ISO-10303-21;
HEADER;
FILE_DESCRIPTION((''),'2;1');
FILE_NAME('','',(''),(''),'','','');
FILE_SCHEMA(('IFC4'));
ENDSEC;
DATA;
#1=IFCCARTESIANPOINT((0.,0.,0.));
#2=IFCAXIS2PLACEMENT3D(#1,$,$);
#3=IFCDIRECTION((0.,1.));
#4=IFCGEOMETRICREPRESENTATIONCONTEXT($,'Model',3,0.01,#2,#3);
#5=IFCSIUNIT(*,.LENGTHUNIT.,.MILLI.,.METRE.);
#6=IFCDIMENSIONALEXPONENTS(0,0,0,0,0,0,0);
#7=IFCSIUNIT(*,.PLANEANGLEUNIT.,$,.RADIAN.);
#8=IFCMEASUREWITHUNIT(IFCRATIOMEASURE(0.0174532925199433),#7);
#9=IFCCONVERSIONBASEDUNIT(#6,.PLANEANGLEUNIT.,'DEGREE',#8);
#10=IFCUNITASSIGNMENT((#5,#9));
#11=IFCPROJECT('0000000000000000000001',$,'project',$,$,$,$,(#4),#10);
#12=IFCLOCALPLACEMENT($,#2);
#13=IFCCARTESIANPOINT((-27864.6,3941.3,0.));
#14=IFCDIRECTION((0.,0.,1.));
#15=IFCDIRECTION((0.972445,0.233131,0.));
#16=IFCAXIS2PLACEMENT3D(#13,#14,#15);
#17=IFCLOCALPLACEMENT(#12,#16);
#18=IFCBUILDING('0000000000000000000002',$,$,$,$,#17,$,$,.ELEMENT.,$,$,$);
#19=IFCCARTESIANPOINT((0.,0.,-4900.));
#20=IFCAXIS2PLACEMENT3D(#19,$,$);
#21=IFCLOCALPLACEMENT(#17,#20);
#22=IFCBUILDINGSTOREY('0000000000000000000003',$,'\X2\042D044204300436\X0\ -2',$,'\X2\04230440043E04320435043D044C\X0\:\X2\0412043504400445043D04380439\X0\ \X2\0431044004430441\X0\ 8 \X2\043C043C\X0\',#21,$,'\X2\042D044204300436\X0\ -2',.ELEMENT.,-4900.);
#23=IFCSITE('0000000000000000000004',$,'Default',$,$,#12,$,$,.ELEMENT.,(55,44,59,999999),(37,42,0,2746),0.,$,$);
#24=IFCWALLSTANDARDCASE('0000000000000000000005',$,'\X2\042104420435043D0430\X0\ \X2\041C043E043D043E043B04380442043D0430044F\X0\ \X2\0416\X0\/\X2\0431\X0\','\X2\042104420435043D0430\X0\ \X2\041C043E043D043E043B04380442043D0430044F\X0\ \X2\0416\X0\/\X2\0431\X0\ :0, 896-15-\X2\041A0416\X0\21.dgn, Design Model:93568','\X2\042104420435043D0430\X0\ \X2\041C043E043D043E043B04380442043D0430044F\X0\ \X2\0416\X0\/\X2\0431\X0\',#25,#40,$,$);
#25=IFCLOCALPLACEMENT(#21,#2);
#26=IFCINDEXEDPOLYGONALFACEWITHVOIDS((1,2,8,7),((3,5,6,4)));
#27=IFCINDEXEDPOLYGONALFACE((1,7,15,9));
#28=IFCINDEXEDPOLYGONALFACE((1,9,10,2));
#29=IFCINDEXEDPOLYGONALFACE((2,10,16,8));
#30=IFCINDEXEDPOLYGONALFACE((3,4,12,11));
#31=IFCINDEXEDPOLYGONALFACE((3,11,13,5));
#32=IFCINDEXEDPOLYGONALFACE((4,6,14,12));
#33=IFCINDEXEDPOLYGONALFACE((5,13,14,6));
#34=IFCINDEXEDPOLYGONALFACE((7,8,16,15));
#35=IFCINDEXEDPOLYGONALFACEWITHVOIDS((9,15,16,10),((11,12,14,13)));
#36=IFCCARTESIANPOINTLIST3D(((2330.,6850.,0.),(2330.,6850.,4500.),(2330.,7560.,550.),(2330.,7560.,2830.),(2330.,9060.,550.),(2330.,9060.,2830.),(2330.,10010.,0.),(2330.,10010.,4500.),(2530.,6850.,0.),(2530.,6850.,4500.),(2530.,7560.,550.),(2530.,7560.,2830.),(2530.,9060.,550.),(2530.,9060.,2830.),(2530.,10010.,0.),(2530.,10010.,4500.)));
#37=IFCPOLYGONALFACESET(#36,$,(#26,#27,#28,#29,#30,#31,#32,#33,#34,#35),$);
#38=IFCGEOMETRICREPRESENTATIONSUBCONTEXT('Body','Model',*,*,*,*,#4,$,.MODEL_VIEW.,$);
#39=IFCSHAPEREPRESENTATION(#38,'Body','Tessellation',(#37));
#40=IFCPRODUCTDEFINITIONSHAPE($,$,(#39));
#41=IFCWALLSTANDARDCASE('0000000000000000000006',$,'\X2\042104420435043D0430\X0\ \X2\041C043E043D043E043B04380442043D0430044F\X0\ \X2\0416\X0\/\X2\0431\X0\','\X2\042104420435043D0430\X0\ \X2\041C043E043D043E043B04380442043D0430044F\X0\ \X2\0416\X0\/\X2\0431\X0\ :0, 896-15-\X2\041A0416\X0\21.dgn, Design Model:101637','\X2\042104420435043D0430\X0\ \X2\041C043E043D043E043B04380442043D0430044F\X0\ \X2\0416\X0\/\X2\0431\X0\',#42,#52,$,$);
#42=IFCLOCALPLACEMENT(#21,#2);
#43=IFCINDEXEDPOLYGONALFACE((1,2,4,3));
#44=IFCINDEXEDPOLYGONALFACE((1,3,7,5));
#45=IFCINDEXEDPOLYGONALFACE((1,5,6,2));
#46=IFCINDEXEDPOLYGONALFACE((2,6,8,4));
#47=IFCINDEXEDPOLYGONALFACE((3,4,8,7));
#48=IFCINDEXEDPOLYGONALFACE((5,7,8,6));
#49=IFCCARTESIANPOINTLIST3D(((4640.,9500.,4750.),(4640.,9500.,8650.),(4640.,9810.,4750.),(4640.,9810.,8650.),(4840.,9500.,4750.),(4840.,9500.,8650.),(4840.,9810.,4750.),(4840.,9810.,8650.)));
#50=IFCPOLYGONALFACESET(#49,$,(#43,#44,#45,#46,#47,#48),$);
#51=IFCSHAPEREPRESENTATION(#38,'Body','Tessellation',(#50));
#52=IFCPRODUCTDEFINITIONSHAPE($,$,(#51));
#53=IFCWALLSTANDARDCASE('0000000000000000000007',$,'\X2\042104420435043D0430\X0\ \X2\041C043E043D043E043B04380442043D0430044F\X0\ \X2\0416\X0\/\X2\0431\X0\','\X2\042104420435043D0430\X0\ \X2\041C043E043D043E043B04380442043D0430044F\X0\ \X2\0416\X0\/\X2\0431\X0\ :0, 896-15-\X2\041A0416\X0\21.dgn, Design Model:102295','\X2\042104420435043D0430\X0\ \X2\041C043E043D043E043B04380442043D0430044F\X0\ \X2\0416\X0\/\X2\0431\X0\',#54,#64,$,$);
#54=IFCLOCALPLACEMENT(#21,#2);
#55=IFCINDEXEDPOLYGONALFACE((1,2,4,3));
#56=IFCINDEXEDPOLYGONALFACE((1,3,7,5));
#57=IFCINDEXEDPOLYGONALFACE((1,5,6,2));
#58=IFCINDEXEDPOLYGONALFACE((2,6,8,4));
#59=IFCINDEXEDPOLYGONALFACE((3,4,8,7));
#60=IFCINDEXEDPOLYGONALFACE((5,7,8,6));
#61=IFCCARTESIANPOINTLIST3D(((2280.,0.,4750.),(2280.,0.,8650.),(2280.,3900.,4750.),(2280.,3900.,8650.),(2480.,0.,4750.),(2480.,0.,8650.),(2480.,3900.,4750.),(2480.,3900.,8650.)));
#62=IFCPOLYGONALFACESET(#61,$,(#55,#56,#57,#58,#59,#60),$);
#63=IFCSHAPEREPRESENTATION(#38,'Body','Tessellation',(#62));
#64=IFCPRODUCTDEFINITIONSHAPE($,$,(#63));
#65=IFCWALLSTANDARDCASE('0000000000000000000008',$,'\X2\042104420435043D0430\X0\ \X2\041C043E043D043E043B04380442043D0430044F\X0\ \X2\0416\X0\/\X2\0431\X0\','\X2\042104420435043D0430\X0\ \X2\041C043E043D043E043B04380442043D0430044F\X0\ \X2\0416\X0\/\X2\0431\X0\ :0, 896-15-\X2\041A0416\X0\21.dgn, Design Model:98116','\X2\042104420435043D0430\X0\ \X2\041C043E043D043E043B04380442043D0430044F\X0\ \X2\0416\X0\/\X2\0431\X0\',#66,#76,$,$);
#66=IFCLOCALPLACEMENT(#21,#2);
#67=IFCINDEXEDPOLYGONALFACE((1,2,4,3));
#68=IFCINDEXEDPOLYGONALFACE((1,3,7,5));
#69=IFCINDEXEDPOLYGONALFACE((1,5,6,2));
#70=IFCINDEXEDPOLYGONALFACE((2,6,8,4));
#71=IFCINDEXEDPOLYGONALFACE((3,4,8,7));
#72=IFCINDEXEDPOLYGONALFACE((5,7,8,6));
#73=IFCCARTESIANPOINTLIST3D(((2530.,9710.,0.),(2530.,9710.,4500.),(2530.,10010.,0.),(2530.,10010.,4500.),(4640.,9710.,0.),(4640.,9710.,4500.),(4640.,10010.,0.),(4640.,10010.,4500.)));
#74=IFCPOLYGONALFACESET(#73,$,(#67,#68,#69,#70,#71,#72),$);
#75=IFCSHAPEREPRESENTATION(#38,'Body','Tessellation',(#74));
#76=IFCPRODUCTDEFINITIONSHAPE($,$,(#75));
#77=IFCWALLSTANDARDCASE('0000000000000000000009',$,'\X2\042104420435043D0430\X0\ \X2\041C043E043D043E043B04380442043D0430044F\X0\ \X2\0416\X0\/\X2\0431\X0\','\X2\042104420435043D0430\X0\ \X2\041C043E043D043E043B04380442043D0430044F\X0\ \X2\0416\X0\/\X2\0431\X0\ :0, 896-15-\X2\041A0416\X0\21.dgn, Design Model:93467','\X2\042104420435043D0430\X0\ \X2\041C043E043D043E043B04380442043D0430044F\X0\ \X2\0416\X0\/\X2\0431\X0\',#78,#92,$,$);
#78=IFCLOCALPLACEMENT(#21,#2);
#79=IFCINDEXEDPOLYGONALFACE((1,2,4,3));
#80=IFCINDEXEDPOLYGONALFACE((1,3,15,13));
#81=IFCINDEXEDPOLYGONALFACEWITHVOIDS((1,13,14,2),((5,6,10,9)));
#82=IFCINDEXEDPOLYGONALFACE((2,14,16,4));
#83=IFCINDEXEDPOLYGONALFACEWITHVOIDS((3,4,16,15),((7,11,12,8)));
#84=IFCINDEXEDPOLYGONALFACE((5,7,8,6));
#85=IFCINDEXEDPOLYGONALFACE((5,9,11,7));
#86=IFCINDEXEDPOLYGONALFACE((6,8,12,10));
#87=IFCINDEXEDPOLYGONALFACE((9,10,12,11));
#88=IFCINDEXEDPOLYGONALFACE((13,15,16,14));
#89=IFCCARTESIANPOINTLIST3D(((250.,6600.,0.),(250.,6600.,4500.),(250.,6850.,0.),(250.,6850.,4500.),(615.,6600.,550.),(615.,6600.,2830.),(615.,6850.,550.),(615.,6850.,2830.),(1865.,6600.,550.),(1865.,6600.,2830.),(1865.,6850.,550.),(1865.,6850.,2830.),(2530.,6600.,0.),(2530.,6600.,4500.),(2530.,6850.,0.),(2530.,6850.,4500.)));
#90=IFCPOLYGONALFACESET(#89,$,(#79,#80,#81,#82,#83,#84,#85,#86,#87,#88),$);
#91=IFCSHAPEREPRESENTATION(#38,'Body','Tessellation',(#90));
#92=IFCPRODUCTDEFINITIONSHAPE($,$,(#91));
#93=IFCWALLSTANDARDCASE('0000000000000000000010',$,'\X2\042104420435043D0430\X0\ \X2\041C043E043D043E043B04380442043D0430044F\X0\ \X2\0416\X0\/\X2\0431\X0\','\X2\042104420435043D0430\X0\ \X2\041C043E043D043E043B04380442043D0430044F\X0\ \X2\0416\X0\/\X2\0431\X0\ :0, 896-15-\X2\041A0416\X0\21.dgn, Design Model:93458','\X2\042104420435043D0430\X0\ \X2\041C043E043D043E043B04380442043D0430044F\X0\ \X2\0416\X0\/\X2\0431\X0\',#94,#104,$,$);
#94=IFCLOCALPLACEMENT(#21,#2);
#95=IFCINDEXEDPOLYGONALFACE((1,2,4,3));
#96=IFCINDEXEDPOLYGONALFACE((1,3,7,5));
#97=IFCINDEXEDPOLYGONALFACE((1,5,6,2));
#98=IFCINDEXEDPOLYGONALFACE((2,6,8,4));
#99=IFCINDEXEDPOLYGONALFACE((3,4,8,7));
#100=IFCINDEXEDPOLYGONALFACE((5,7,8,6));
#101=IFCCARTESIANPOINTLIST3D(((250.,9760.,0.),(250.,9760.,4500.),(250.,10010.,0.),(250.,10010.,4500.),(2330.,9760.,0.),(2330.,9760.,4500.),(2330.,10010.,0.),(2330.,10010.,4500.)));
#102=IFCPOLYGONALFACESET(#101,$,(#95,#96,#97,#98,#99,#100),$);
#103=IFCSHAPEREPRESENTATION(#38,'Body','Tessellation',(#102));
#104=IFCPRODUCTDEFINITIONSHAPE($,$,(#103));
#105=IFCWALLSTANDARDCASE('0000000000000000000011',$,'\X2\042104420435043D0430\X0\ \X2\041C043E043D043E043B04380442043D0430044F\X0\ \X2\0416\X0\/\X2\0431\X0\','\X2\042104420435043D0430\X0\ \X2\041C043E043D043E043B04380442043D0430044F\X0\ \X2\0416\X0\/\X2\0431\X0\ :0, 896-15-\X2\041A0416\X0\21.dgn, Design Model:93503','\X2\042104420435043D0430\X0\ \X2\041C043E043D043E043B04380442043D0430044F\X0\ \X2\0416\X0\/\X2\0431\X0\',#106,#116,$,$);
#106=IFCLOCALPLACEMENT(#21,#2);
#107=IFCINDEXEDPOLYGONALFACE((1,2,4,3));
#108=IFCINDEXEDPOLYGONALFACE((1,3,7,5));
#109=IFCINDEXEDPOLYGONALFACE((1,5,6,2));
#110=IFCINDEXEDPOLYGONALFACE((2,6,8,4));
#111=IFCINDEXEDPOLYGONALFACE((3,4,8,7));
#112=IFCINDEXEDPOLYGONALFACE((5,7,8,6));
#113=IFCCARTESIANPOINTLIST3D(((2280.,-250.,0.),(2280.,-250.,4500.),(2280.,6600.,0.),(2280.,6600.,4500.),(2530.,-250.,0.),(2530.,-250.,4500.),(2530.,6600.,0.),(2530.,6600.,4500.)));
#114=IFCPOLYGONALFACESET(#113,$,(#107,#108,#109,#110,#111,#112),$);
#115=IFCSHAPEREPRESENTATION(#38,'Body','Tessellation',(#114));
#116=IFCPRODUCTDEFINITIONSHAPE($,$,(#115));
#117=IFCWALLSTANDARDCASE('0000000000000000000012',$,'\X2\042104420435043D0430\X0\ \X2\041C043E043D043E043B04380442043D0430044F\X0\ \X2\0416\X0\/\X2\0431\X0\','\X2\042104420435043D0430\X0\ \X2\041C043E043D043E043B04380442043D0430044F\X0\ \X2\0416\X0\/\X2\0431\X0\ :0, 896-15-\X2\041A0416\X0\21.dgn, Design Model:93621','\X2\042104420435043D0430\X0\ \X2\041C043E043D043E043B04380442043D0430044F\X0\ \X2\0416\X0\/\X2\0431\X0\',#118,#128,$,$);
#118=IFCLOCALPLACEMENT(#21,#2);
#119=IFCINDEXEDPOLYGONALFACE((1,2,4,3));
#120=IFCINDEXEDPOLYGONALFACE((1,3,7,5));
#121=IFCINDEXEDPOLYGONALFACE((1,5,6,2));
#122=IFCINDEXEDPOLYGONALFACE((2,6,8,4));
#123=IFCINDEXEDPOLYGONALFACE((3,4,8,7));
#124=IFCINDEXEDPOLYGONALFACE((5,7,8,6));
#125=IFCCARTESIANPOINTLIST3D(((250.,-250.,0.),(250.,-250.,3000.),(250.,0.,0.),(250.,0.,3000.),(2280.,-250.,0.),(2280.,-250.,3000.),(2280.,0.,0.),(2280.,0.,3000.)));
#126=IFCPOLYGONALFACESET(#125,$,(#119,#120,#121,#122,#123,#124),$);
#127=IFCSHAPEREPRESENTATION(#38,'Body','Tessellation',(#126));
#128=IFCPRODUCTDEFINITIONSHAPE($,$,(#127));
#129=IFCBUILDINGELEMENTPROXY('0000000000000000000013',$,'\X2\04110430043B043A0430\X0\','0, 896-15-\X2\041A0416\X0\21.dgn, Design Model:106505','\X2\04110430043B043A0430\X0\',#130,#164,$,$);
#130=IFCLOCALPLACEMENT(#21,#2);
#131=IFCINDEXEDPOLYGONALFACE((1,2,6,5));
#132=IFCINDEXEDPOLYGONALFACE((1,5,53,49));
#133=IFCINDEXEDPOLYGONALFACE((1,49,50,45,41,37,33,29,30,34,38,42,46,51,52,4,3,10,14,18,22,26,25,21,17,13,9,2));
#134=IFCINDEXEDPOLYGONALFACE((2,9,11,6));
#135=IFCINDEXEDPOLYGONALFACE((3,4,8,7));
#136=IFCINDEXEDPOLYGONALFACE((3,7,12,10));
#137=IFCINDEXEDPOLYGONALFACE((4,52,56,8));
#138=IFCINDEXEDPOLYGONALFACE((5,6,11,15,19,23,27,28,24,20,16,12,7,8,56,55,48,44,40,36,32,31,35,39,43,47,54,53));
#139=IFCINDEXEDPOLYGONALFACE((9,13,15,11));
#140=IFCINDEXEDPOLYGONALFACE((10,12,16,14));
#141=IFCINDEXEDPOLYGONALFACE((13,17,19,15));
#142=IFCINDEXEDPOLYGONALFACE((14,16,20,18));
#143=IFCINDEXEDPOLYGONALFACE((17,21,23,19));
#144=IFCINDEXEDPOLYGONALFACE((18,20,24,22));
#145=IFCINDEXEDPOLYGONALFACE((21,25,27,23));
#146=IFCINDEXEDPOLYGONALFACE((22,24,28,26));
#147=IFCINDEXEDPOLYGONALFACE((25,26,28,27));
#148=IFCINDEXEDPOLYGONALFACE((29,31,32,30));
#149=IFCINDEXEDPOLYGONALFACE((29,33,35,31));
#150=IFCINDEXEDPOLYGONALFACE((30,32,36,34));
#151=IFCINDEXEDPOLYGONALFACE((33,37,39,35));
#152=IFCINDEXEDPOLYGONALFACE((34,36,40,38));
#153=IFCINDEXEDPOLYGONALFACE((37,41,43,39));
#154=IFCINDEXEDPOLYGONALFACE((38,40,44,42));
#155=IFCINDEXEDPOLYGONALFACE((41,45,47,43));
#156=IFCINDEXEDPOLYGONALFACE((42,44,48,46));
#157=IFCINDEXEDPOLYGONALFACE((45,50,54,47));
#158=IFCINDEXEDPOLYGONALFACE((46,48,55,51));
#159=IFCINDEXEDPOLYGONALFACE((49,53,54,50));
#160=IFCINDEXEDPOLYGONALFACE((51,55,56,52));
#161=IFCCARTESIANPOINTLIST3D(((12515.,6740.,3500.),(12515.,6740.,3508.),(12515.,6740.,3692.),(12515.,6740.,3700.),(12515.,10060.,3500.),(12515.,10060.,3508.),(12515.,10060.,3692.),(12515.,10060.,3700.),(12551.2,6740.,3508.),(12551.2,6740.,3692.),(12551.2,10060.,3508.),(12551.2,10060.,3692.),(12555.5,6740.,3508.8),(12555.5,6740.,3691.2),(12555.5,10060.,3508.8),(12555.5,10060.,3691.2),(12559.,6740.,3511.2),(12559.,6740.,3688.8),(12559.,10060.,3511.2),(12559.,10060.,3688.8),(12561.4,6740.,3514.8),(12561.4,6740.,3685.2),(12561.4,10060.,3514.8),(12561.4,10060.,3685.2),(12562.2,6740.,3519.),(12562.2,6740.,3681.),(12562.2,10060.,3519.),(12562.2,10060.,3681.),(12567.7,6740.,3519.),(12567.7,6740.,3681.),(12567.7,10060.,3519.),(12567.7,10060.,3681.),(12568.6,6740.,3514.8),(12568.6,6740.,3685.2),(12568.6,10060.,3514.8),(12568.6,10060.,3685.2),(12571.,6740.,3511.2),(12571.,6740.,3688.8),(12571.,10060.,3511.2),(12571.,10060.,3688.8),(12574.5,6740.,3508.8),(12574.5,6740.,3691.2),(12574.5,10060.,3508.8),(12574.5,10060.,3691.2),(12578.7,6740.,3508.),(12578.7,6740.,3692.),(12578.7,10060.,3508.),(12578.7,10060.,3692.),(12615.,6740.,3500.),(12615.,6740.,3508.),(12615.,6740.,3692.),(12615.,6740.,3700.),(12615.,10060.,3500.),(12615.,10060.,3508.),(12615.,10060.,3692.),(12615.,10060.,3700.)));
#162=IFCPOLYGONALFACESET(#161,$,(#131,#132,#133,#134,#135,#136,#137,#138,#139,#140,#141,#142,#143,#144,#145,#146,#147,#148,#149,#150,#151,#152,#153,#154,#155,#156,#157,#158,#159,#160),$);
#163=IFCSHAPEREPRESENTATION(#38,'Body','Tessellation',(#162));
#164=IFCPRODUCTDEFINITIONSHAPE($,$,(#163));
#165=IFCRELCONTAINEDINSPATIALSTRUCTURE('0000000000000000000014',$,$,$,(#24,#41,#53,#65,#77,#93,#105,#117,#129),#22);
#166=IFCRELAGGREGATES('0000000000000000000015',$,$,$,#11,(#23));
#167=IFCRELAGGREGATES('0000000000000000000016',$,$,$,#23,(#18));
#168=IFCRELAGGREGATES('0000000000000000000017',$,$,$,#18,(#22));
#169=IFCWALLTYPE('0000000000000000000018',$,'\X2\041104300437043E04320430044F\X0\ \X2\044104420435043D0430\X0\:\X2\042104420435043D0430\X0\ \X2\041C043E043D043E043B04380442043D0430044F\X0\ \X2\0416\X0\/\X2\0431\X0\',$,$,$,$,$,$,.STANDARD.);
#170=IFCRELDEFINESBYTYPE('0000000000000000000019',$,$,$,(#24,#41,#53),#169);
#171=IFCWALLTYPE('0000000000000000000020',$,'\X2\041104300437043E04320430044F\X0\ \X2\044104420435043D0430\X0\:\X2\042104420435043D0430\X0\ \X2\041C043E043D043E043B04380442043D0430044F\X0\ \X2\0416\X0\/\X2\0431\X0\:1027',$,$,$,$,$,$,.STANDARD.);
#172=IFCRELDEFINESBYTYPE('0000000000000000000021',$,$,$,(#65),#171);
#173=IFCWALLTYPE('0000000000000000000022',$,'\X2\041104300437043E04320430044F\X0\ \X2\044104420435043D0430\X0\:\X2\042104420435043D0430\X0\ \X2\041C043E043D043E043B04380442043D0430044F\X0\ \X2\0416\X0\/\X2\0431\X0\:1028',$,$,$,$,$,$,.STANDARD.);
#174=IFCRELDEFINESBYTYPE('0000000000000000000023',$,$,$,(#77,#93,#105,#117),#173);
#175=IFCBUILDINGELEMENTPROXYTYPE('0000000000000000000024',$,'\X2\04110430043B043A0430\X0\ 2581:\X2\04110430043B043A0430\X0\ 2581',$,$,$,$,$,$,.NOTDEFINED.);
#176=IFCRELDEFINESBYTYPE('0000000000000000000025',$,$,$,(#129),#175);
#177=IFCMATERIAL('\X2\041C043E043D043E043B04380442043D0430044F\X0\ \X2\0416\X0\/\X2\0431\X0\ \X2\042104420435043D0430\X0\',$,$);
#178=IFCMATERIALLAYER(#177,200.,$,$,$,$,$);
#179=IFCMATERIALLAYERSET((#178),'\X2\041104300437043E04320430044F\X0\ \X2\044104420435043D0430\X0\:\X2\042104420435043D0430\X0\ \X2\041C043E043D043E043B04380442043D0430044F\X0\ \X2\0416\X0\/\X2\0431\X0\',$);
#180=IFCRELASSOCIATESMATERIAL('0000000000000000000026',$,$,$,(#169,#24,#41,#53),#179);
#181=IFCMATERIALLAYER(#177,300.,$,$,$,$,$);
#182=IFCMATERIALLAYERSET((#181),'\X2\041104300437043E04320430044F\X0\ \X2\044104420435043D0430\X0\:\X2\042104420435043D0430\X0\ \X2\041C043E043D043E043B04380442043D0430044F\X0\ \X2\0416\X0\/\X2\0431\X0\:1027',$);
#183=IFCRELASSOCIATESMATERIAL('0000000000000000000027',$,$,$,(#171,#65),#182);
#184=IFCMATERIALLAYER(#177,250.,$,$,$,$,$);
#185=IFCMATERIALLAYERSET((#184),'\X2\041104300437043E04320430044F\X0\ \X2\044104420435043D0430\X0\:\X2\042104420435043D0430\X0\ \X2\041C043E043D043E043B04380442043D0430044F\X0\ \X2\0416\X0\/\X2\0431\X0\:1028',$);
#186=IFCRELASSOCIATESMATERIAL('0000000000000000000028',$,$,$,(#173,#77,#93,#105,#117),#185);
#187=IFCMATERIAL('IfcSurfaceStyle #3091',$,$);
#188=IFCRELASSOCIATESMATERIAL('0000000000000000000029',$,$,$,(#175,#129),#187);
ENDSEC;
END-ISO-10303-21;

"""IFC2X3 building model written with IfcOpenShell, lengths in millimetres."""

from ifc_helpers import new_model, entity, si_unit, converted_unit, direction, frame, frame_2d, origin, origin_2d_with_axis, place, context, subcontext, project, spatial, polyline, rectangle, outline, extrude, source, transform, mapped, material, layer, layer_set, layer_usage, type_object, type_shapes, element, save


model = new_model("IFC2X3")

# Units and contexts
model_context = context("Model", 3, precision=0.01, world=origin(), true_north=direction((0.0, 1.0)))
body_context = subcontext(model_context, "Body", "Model", "MODEL_VIEW")
ifc_project = project(units=[si_unit("LENGTHUNIT", "METRE", prefix="MILLI"), converted_unit("PLANEANGLEUNIT", "DEGREE", entity("IfcRatioMeasure", 0.0174532925199433), si_unit("PLANEANGLEUNIT", "RADIAN"), dimensions=[0, 0, 0, 0, 0, 0, 0])], contexts=[model_context])

# Site, building, storey
site_placement = place(None, origin())
site = spatial("IfcSite", under=ifc_project, at=site_placement, Name="Default", CompositionType="ELEMENT", RefLatitude=(55, 44, 59, 999999), RefLongitude=(37, 42, 0, 2746), RefElevation=0.0)
building_placement = place(site_placement, frame((-27864.6, 3941.3, 0.0), z_axis=(0.0, 0.0, 1.0), x_axis=(0.972445, 0.233131, 0.0)))
building = spatial("IfcBuilding", under=site, at=building_placement, CompositionType="ELEMENT")
storey_placement = place(building_placement, frame((0.0, 0.0, -4900.0)))
storey = spatial("IfcBuildingStorey", under=building, at=storey_placement, Name="Этаж -2", ObjectType="Уровень:Верхний брус 8 мм", LongName="Этаж -2", CompositionType="ELEMENT", Elevation=-4900.0)

# Wall, opening
ifc_material_1 = material(Name="Монолитная Ж/б Стена")
ifc_layer_1 = layer(ifc_material_1, 200.0)
ifc_layer_set_1 = layer_set([ifc_layer_1], Name="Базовая стена:Стена Монолитная Ж/б")
ifc_layer_usage_1 = layer_usage(ifc_layer_set_1, "AXIS2", "NEGATIVE", 100.0)
wall_type_1 = type_object("IfcWallType", Name="Базовая стена:Стена Монолитная Ж/б", PredefinedType="STANDARD", material=ifc_layer_set_1)
wall_1_placement = place(storey_placement, frame((2430.0, 6850.0, 0.0), z_axis=(0.0, 0.0, 1.0), x_axis=(0.0, 1.0, 0.0)))
wall_1 = element("IfcWallStandardCase", 1, at=wall_1_placement, inside=storey, type_object=wall_type_1, material=ifc_layer_usage_1, Name="Стена Монолитная Ж/б", Description="Стена Монолитная Ж/б :0, 896-15-КЖ21.dgn, Design Model:93568", ObjectType="Стена Монолитная Ж/б", context=body_context, shape_type="SweptSolid", body=[
    extrude(rectangle(XDim=3160.0, YDim=200.0, at=frame_2d((1580.0, 0.0), x_axis=(-1.0, 0.0))), origin(), (0.0, 0.0, 1.0), 4500.0),
])
opening_1_placement = place(wall_1_placement, origin())
element("IfcOpeningElement", 2, at=opening_1_placement, cuts=wall_1, ObjectType="Opening", context=body_context, shape_type="SweptSolid", body=[
    extrude(rectangle(XDim=2280.0, YDim=1500.0, at=origin_2d_with_axis()), frame((1460.0, -100.0, 1690.0), z_axis=(0.0, 1.0, 0.0), x_axis=(0.0, 0.0, -1.0)), (0.0, 0.0, 1.0), 200.0),
])

# Walls
ifc_layer_usage_2 = layer_usage(ifc_layer_set_1, "AXIS2", "NEGATIVE", 100.0)
wall_2_placement = place(storey_placement, frame((4740.0, 9500.0, 4750.0), z_axis=(0.0, 0.0, 1.0), x_axis=(0.0, 1.0, 0.0)))
element("IfcWallStandardCase", 3, at=wall_2_placement, inside=storey, type_object=wall_type_1, material=ifc_layer_usage_2, Name="Стена Монолитная Ж/б", Description="Стена Монолитная Ж/б :0, 896-15-КЖ21.dgn, Design Model:101637", ObjectType="Стена Монолитная Ж/б", context=body_context, shape_type="SweptSolid", body=[
    extrude(rectangle(XDim=310.0, YDim=200.0, at=frame_2d((155.0, 0.0), x_axis=(-1.0, 0.0))), origin(), (0.0, 0.0, 1.0), 3900.0),
])
ifc_layer_usage_3 = layer_usage(ifc_layer_set_1, "AXIS2", "NEGATIVE", 100.0)
wall_3_placement = place(storey_placement, frame((2380.0, 3900.0, 4750.0), z_axis=(0.0, 0.0, 1.0), x_axis=(0.0, -1.0, 0.0)))
element("IfcWallStandardCase", 4, at=wall_3_placement, inside=storey, type_object=wall_type_1, material=ifc_layer_usage_3, Name="Стена Монолитная Ж/б", Description="Стена Монолитная Ж/б :0, 896-15-КЖ21.dgn, Design Model:102295", ObjectType="Стена Монолитная Ж/б", context=body_context, shape_type="SweptSolid", body=[
    extrude(rectangle(XDim=3900.0, YDim=200.0, at=frame_2d((1950.0, 0.0), x_axis=(-1.0, 0.0))), origin(), (0.0, 0.0, 1.0), 3900.0),
])
ifc_layer_2 = layer(ifc_material_1, 300.0)
ifc_layer_set_2 = layer_set([ifc_layer_2], Name="Базовая стена:Стена Монолитная Ж/б:1027")
ifc_layer_usage_4 = layer_usage(ifc_layer_set_2, "AXIS2", "NEGATIVE", 150.0)
wall_type_2 = type_object("IfcWallType", Name="Базовая стена:Стена Монолитная Ж/б:1027", PredefinedType="STANDARD", material=ifc_layer_set_2)
wall_4_placement = place(storey_placement, frame((4640.0, 9860.0, 0.0), z_axis=(0.0, 0.0, 1.0), x_axis=(-1.0, 0.0, 0.0)))
element("IfcWallStandardCase", 5, at=wall_4_placement, inside=storey, type_object=wall_type_2, material=ifc_layer_usage_4, Name="Стена Монолитная Ж/б", Description="Стена Монолитная Ж/б :0, 896-15-КЖ21.dgn, Design Model:98116", ObjectType="Стена Монолитная Ж/б", context=body_context, shape_type="SweptSolid", body=[
    extrude(rectangle(XDim=2110.0, YDim=300.0, at=frame_2d((1055.0, 0.0), x_axis=(-1.0, 0.0))), origin(), (0.0, 0.0, 1.0), 4500.0),
])

# Wall, opening
ifc_layer_3 = layer(ifc_material_1, 250.0)
ifc_layer_set_3 = layer_set([ifc_layer_3], Name="Базовая стена:Стена Монолитная Ж/б:1028")
ifc_layer_usage_5 = layer_usage(ifc_layer_set_3, "AXIS2", "NEGATIVE", 125.0)
wall_type_3 = type_object("IfcWallType", Name="Базовая стена:Стена Монолитная Ж/б:1028", PredefinedType="STANDARD", material=ifc_layer_set_3)
wall_5_placement = place(storey_placement, frame((2530.0, 6725.0, 0.0), z_axis=(0.0, 0.0, 1.0), x_axis=(-1.0, 0.0, 0.0)))
wall_5 = element("IfcWallStandardCase", 6, at=wall_5_placement, inside=storey, type_object=wall_type_3, material=ifc_layer_usage_5, Name="Стена Монолитная Ж/б", Description="Стена Монолитная Ж/б :0, 896-15-КЖ21.dgn, Design Model:93467", ObjectType="Стена Монолитная Ж/б", context=body_context, shape_type="SweptSolid", body=[
    extrude(rectangle(XDim=2280.0, YDim=250.0, at=frame_2d((1140.0, 0.0), x_axis=(-1.0, 0.0))), origin(), (0.0, 0.0, 1.0), 4500.0),
])
opening_2_placement = place(wall_5_placement, origin())
element("IfcOpeningElement", 7, at=opening_2_placement, cuts=wall_5, ObjectType="Opening", context=body_context, shape_type="SweptSolid", body=[
    extrude(rectangle(XDim=2280.0, YDim=1250.0, at=origin_2d_with_axis()), frame((1290.0, -125.0, 1690.0), z_axis=(0.0, 1.0, 0.0), x_axis=(0.0, 0.0, -1.0)), (0.0, 0.0, 1.0), 250.0),
])

# Walls
ifc_layer_usage_6 = layer_usage(ifc_layer_set_3, "AXIS2", "NEGATIVE", 125.0)
wall_6_placement = place(storey_placement, frame((250.0, 9885.0, 0.0)))
element("IfcWallStandardCase", 8, at=wall_6_placement, inside=storey, type_object=wall_type_3, material=ifc_layer_usage_6, Name="Стена Монолитная Ж/б", Description="Стена Монолитная Ж/б :0, 896-15-КЖ21.dgn, Design Model:93458", ObjectType="Стена Монолитная Ж/б", context=body_context, shape_type="SweptSolid", body=[
    extrude(rectangle(XDim=2080.0, YDim=250.0, at=frame_2d((1040.0, 0.0), x_axis=(-1.0, 0.0))), origin(), (0.0, 0.0, 1.0), 4500.0),
])
ifc_layer_usage_7 = layer_usage(ifc_layer_set_3, "AXIS2", "NEGATIVE", 125.0)
wall_7_placement = place(storey_placement, frame((2405.0, 6600.0, 0.0), z_axis=(0.0, 0.0, 1.0), x_axis=(0.0, -1.0, 0.0)))
element("IfcWallStandardCase", 9, at=wall_7_placement, inside=storey, type_object=wall_type_3, material=ifc_layer_usage_7, Name="Стена Монолитная Ж/б", Description="Стена Монолитная Ж/б :0, 896-15-КЖ21.dgn, Design Model:93503", ObjectType="Стена Монолитная Ж/б", context=body_context, shape_type="SweptSolid", body=[
    extrude(rectangle(XDim=6850.0, YDim=250.0, at=frame_2d((3425.0, 0.0), x_axis=(-1.0, 0.0))), origin(), (0.0, 0.0, 1.0), 4500.0),
])
ifc_layer_usage_8 = layer_usage(ifc_layer_set_3, "AXIS2", "NEGATIVE", 125.0)
wall_8_placement = place(storey_placement, frame((2280.0, -125.0, 0.0), z_axis=(0.0, 0.0, 1.0), x_axis=(-1.0, 0.0, 0.0)))
element("IfcWallStandardCase", 10, at=wall_8_placement, inside=storey, type_object=wall_type_3, material=ifc_layer_usage_8, Name="Стена Монолитная Ж/б", Description="Стена Монолитная Ж/б :0, 896-15-КЖ21.dgn, Design Model:93621", ObjectType="Стена Монолитная Ж/б", context=body_context, shape_type="SweptSolid", body=[
    extrude(rectangle(XDim=2030.0, YDim=250.0, at=frame_2d((1015.0, 0.0), x_axis=(-1.0, 0.0))), origin(), (0.0, 0.0, 1.0), 3000.0),
])

# Building element proxy
ifc_material_2 = material(Name="IfcSurfaceStyle #3091")
building_element_proxy_type_1 = type_object("IfcBuildingElementProxyType", Name="Балка 2581:Балка 2581", PredefinedType="NOTDEFINED", material=ifc_material_2)
shared_shape_1 = source(origin(), body_context, "Body", "SweptSolid", [
    extrude(outline(polyline([(92.0, -50.0), (100.0, -50.0), (100.0, 50.0), (92.0, 50.0), (92.0, 13.8), (91.2, 9.5), (88.8, 6.0), (85.2, 3.6), (81.0, 2.8), (-81.0, 2.8), (-85.2, 3.6), (-88.8, 6.0), (-91.2, 9.5), (-92.0, 13.8), (-92.0, 50.0), (-100.0, 50.0), (-100.0, -50.0), (-92.0, -50.0), (-92.0, -13.7), (-91.2, -9.5), (-88.8, -6.0), (-85.2, -3.6), (-81.0, -2.7), (81.0, -2.7), (85.2, -3.6), (88.8, -6.0), (91.2, -9.5), (92.0, -13.7), (92.0, -50.0)])), frame((12565.0, 6740.0, -1300.0), z_axis=(0.0, 1.0, 0.0), x_axis=(0.0, 0.0, -1.0)), (0.0, 0.0, 1.0), 3320.0),
])
type_shapes(building_element_proxy_type_1, [shared_shape_1])
proxy_1_placement = place(storey_placement, frame((0.0, 0.0, 4900.0)))
element("IfcBuildingElementProxy", 11, at=proxy_1_placement, inside=storey, type_object=building_element_proxy_type_1, material=ifc_material_2, Name="Балка", Description="0, 896-15-КЖ21.dgn, Design Model:106505", ObjectType="Балка", context=body_context, shape_type="MappedRepresentation", body=[
    mapped(shared_shape_1, transform((0.0, 0.0, 0.0), scale=1.0)),
])

save(model, "model.ifc")
